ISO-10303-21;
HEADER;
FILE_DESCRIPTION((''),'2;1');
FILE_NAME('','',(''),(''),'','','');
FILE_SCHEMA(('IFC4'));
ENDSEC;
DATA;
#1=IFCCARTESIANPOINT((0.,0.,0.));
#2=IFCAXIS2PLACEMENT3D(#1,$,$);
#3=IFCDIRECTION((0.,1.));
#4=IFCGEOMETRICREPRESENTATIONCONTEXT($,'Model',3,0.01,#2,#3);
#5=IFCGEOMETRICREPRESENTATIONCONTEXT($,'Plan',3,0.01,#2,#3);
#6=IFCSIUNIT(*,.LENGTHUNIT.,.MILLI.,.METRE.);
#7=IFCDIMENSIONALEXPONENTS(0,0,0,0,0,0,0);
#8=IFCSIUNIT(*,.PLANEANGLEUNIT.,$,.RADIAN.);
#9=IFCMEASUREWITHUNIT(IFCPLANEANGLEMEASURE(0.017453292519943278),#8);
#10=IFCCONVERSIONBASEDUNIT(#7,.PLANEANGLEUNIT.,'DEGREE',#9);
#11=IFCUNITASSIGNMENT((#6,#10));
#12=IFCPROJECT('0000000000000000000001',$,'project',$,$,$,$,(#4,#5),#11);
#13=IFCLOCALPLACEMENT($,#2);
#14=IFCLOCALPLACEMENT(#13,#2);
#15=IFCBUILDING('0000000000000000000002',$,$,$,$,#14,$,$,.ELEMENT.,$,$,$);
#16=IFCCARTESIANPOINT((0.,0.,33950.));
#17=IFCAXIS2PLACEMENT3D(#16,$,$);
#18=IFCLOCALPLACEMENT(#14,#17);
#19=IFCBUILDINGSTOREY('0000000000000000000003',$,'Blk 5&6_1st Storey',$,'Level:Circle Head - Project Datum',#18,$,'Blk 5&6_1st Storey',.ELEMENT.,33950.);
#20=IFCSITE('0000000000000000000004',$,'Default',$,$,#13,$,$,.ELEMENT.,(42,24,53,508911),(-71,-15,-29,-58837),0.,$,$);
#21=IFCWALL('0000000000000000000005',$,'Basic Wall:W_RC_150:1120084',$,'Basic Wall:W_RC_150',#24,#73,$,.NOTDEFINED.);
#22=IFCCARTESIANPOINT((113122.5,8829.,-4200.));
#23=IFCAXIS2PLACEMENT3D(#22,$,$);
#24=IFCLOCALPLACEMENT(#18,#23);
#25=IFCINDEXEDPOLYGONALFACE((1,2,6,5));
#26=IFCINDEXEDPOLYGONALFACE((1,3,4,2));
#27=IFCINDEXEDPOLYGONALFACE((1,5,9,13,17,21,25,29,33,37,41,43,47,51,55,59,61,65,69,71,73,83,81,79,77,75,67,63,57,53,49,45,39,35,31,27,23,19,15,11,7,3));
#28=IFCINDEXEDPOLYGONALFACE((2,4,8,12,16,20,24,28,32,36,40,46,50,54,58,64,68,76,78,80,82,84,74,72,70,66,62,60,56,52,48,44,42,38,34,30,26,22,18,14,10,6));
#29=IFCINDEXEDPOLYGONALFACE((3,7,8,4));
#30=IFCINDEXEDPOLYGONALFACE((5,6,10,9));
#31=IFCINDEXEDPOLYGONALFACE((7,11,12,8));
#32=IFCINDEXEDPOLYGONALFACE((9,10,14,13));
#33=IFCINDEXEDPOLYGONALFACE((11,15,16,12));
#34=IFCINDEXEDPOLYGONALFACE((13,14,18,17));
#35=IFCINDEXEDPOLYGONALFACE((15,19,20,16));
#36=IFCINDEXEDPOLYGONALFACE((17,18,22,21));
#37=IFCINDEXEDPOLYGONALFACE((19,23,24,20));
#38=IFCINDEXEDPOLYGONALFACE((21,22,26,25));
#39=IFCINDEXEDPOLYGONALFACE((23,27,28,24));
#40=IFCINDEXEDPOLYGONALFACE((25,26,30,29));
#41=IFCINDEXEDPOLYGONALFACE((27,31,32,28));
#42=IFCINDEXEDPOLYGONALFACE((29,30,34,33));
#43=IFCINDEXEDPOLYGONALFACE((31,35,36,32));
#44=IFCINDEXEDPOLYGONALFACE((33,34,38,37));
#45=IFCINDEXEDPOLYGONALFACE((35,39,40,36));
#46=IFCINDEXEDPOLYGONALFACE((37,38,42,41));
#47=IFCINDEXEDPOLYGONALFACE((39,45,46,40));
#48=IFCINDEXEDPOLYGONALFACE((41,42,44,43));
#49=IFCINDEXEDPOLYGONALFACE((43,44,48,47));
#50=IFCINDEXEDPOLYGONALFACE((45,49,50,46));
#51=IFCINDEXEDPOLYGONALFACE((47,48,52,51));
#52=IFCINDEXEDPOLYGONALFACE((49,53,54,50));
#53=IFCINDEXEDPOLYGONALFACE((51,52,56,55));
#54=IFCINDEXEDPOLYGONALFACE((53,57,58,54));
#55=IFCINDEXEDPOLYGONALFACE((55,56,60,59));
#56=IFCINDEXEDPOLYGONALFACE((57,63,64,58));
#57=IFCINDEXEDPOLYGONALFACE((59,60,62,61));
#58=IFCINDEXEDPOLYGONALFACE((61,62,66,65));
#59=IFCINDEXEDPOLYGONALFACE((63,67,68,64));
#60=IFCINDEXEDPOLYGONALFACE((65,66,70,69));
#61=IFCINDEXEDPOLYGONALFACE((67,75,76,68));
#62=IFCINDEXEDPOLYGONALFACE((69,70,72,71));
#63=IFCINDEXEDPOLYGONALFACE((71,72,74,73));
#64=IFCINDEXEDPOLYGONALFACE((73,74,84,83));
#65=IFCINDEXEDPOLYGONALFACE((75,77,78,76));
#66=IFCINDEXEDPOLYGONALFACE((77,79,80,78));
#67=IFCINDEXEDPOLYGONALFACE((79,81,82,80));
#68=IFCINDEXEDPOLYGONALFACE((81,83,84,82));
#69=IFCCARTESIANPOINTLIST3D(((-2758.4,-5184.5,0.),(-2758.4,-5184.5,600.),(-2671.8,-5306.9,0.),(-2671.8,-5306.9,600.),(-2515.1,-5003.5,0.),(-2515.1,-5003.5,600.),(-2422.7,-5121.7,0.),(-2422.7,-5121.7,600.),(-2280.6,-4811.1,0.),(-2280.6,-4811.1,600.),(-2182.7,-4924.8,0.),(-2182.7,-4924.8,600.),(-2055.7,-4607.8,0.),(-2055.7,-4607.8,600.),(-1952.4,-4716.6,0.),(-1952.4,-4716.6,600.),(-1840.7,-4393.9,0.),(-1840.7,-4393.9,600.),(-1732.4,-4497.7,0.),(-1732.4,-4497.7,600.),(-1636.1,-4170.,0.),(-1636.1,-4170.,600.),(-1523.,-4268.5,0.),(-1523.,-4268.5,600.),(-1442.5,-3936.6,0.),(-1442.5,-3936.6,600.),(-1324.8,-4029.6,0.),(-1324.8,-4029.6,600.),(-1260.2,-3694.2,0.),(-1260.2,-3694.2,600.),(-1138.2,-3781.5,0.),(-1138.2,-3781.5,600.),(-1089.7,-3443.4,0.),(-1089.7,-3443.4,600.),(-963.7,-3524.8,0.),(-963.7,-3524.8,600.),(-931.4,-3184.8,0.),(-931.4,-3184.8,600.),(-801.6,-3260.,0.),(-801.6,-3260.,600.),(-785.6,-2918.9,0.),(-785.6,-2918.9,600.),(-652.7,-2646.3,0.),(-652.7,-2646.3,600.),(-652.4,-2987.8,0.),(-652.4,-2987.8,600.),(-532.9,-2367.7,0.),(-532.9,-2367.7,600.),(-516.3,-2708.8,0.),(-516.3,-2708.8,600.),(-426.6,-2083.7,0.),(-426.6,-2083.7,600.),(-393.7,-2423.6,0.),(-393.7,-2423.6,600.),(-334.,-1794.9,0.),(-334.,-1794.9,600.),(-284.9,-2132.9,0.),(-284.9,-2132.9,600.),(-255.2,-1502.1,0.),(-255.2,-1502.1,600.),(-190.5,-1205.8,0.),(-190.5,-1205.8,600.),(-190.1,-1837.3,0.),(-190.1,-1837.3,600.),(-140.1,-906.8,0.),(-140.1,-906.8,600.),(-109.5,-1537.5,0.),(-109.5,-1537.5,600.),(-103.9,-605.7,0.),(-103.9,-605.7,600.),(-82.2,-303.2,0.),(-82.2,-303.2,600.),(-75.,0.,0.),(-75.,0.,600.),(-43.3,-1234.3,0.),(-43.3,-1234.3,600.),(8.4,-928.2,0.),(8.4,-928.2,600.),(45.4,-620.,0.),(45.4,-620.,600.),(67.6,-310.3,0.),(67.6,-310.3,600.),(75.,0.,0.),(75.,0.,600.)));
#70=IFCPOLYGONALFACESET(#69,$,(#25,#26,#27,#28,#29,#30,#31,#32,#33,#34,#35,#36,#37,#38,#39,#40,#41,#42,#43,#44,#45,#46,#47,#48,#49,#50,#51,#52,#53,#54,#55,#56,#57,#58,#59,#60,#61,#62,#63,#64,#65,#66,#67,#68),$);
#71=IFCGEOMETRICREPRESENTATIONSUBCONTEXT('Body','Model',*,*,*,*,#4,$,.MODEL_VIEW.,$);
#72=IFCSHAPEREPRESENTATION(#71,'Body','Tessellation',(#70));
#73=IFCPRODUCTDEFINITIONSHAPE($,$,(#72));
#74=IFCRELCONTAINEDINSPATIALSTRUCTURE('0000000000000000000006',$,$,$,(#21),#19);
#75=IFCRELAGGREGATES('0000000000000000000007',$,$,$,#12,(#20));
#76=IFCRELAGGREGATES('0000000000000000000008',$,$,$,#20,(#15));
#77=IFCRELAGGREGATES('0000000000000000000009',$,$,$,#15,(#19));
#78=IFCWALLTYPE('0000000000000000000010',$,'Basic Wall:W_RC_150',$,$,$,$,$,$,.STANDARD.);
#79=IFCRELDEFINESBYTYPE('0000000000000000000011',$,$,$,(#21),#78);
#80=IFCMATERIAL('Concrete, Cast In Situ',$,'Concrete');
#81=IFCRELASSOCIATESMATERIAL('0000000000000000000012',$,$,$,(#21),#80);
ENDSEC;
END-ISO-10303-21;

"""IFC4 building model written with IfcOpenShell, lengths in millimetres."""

from ifc_helpers import new_model, entity, si_unit, converted_unit, direction, frame, origin, place, context, subcontext, project, spatial, line, arc, indexed_curve, outline, extrude, material, type_object, element, save


model = new_model("IFC4")

# Units and contexts
model_context = context("Model", 3, precision=0.01, world=origin(), true_north=direction((0.0, 1.0)))
plan_context = context("Plan", 3, precision=0.01, world=origin(), true_north=direction((0.0, 1.0)))
body_context = subcontext(model_context, "Body", "Model", "MODEL_VIEW")
ifc_project = project(units=[si_unit("LENGTHUNIT", "METRE", prefix="MILLI"), converted_unit("PLANEANGLEUNIT", "DEGREE", entity("IfcPlaneAngleMeasure", 0.017453292519943278), si_unit("PLANEANGLEUNIT", "RADIAN"), dimensions=[0, 0, 0, 0, 0, 0, 0])], contexts=[model_context, plan_context])

# Site, building, storey
site_placement = place(None, origin())
site = spatial("IfcSite", under=ifc_project, at=site_placement, Name="Default", CompositionType="ELEMENT", RefLatitude=(42, 24, 53, 508911), RefLongitude=(-71, -15, -29, -58837), RefElevation=0.0)
building_placement = place(site_placement, origin())
building = spatial("IfcBuilding", under=site, at=building_placement, CompositionType="ELEMENT")
storey_placement = place(building_placement, frame((0.0, 0.0, 33950.0)))
storey = spatial("IfcBuildingStorey", under=building, at=storey_placement, Name="Blk 5&6_1st Storey", ObjectType="Level:Circle Head - Project Datum", LongName="Blk 5&6_1st Storey", CompositionType="ELEMENT", Elevation=33950.0)

# Wall
ifc_material_1 = material(Name="Concrete, Cast In Situ", Category="Concrete")
wall_type_1 = type_object("IfcWallType", Name="Basic Wall:W_RC_150", PredefinedType="STANDARD")
wall_1_placement = place(storey_placement, frame((113122.5, 8829.0, -4200.0)))
element("IfcWall", 1, at=wall_1_placement, inside=storey, type_object=wall_type_1, material=ifc_material_1, Name="Basic Wall:W_RC_150:1120084", ObjectType="Basic Wall:W_RC_150", PredefinedType="NOTDEFINED", context=body_context, shape_type="SweptSolid", body=[
    extrude(outline(indexed_curve([(-2671.8, -5306.9), (-652.4, -2987.8), (75.0, 0.0), (-75.0, 0.0), (-785.6, -2918.9), (-2758.4, -5184.5)], segments=[arc(1, 2, 3), line(3, 4), arc(4, 5, 6), line(6, 1)], self_intersect=False)), origin(), (0.0, 0.0, 1.0), 600.0),
])

save(model, "model.ifc")
